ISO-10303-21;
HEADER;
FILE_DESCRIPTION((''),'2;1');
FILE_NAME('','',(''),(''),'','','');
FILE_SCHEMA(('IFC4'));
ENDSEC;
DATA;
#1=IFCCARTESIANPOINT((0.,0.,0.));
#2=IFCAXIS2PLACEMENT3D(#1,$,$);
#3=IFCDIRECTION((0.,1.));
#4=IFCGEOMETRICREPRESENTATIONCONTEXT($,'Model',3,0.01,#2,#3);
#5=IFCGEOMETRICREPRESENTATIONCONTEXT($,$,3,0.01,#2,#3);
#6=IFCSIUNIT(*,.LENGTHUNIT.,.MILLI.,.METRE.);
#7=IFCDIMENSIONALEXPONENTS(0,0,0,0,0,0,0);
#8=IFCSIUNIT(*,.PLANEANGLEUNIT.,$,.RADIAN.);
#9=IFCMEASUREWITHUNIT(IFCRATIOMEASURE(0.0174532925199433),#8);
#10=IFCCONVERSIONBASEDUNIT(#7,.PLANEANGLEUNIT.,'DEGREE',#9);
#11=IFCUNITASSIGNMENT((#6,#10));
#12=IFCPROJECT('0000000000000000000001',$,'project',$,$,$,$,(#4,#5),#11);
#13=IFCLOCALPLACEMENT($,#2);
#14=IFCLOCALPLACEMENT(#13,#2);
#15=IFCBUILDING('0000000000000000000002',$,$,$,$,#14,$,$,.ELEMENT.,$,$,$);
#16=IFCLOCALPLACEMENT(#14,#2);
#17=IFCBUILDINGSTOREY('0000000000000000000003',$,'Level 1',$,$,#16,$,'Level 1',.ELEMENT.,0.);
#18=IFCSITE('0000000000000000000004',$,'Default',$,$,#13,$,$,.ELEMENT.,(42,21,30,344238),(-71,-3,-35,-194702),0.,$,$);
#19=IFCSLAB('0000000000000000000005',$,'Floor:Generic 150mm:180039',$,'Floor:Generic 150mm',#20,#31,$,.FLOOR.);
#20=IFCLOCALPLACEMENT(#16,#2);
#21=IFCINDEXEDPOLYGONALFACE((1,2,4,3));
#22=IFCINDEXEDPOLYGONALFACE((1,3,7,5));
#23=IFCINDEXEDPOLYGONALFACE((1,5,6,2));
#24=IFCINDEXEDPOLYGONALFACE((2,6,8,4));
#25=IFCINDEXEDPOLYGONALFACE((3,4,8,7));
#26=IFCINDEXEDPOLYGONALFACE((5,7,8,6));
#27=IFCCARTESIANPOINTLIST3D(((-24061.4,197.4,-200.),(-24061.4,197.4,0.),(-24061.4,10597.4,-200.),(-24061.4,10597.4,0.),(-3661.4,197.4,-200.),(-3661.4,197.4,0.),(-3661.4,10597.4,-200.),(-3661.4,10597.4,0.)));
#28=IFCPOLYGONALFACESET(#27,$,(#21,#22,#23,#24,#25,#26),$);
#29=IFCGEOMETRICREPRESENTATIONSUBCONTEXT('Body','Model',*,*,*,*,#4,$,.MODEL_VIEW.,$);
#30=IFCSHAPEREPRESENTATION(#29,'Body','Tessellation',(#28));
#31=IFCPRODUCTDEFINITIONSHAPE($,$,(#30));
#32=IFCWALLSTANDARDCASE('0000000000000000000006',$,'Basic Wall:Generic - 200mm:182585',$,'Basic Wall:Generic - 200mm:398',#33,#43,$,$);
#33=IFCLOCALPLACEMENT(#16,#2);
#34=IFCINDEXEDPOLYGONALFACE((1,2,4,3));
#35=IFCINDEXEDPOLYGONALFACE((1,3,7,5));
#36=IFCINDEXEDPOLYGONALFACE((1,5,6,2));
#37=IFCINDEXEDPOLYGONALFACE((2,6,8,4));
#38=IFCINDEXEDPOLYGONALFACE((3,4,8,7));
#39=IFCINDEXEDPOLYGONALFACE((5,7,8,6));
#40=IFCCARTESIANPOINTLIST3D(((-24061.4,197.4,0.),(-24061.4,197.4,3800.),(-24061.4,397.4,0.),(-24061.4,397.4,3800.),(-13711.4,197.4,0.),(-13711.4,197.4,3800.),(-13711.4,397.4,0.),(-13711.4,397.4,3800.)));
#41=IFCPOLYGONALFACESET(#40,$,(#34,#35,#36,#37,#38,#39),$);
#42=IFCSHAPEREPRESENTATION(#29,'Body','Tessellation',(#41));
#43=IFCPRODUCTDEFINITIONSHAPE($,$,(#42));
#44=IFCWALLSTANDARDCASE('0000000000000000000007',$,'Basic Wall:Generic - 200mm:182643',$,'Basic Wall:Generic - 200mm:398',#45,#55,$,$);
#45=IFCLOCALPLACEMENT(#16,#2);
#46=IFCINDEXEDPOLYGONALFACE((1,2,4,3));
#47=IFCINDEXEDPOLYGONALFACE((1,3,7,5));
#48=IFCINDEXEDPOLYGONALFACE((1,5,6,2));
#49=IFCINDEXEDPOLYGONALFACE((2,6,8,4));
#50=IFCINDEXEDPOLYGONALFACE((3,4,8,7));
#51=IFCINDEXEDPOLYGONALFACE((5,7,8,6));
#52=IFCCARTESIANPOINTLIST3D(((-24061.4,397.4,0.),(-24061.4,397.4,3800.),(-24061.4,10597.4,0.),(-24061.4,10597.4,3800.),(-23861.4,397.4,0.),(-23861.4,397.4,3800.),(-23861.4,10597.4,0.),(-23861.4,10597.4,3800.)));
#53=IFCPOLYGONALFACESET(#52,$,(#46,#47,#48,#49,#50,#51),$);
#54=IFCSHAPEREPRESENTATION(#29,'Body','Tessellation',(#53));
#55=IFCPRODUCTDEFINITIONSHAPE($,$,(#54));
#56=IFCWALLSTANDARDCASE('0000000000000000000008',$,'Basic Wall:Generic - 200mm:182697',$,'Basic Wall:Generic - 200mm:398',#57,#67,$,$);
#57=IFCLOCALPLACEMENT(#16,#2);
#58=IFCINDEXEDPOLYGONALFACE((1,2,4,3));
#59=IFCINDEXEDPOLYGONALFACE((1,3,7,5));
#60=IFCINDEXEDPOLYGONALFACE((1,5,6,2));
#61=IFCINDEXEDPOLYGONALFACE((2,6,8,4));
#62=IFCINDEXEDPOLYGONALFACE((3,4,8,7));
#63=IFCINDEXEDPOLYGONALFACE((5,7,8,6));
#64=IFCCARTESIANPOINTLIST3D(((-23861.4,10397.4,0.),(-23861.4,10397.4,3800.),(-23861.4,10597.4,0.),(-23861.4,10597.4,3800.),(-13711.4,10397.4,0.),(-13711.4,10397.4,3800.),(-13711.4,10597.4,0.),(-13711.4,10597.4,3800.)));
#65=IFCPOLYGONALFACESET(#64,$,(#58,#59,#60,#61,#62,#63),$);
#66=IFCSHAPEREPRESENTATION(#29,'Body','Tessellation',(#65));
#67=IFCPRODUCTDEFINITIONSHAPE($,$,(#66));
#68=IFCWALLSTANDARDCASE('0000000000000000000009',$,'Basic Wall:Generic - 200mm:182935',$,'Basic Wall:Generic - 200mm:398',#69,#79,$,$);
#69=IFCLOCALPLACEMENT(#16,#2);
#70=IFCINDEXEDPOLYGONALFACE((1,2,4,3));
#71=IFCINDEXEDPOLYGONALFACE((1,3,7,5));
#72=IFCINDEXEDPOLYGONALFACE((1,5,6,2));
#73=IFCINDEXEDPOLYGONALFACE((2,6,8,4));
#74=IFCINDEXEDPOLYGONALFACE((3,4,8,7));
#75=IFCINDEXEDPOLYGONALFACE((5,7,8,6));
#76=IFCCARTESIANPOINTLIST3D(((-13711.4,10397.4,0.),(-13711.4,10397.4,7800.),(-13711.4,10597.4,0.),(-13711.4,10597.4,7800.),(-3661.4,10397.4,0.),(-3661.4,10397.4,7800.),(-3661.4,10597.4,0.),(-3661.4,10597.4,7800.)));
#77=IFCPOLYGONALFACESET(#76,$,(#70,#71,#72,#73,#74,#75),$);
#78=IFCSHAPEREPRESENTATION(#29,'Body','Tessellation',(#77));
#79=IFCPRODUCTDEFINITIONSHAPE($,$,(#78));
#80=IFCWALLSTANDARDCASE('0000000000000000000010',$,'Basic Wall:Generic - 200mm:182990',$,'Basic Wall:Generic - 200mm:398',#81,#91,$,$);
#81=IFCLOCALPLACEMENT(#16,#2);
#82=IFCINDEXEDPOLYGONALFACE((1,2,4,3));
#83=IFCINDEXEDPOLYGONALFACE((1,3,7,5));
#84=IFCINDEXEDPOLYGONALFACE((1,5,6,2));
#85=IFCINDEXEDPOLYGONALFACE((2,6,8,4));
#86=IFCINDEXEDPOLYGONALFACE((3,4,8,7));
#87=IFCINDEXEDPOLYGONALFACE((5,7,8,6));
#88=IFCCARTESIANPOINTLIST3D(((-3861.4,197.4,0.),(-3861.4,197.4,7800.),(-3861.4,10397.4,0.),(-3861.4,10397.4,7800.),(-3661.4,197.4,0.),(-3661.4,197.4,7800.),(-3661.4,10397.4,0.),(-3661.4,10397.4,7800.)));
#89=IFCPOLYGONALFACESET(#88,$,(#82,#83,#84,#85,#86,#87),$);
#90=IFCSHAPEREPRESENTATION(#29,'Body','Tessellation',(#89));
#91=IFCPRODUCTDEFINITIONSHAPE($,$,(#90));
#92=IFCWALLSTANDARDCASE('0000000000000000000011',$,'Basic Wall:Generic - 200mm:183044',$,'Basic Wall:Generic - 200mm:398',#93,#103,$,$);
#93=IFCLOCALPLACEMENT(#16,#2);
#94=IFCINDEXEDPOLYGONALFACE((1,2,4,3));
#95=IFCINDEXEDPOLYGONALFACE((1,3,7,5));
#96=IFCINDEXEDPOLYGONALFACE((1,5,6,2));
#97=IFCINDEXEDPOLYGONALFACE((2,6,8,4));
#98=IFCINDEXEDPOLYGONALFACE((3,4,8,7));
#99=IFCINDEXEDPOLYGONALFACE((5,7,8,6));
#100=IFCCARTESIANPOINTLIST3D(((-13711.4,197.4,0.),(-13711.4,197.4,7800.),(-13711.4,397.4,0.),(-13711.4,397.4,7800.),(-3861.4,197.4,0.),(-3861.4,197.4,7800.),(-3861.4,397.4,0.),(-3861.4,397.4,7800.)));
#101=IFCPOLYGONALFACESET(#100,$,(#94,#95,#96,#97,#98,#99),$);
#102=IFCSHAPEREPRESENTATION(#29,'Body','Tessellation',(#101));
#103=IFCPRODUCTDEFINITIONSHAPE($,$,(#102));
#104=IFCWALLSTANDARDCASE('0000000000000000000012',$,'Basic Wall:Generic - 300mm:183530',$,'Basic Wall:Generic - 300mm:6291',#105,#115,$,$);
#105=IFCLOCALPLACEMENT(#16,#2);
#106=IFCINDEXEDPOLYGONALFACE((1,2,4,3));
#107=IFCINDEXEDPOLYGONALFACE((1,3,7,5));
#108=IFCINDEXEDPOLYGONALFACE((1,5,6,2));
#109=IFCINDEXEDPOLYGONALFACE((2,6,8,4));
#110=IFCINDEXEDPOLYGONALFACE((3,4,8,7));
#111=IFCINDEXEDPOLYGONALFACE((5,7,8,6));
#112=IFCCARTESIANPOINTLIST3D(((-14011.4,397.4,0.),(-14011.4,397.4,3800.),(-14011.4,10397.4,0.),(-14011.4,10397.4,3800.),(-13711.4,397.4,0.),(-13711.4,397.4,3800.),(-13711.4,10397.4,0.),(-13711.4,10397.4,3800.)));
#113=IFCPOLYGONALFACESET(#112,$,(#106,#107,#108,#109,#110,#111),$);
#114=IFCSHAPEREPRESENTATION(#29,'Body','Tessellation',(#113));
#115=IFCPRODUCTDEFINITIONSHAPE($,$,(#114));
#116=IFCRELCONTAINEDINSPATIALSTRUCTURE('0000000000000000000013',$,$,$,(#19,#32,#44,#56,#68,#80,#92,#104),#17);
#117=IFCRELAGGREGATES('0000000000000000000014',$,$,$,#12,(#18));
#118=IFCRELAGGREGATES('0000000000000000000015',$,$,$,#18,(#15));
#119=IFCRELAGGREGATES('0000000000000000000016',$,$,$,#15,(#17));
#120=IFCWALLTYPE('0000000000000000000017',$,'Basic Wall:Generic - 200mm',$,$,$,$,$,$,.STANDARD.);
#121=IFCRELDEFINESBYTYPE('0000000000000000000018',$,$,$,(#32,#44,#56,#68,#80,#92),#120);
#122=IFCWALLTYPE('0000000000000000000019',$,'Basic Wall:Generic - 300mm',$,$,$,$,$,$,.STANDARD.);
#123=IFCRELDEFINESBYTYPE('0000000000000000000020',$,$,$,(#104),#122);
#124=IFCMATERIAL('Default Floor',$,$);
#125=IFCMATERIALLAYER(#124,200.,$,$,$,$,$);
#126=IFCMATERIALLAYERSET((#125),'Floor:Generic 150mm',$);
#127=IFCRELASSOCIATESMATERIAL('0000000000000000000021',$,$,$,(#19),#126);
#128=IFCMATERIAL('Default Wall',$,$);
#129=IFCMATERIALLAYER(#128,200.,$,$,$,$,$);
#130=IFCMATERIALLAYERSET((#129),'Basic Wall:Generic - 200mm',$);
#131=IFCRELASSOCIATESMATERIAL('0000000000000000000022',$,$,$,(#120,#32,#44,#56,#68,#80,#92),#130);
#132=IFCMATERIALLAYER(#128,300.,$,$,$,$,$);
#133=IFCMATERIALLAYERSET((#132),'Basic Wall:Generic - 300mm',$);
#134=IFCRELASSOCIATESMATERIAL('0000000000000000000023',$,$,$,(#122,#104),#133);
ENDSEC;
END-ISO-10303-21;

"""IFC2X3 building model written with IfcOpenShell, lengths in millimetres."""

from ifc_helpers import new_model, entity, si_unit, converted_unit, direction, frame, frame_2d, origin, origin_2d_with_axis, place, context, subcontext, project, spatial, rectangle, extrude, material, layer, layer_set, layer_usage, type_object, element, save


model = new_model("IFC2X3")

# Units and contexts
model_context = context("Model", 3, precision=0.01, world=origin(), true_north=direction((0.0, 1.0)))
context_of_model = context(None, 3, precision=0.01, world=origin(), true_north=direction((0.0, 1.0)))
body_context = subcontext(model_context, "Body", "Model", "MODEL_VIEW")
ifc_project = project(units=[si_unit("LENGTHUNIT", "METRE", prefix="MILLI"), converted_unit("PLANEANGLEUNIT", "DEGREE", entity("IfcRatioMeasure", 0.0174532925199433), si_unit("PLANEANGLEUNIT", "RADIAN"), dimensions=[0, 0, 0, 0, 0, 0, 0])], contexts=[model_context, context_of_model])

# Site, building, storey
site_placement = place(None, origin())
site = spatial("IfcSite", under=ifc_project, at=site_placement, Name="Default", CompositionType="ELEMENT", RefLatitude=(42, 21, 30, 344238), RefLongitude=(-71, -3, -35, -194702), RefElevation=0.0)
building_placement = place(site_placement, origin())
building = spatial("IfcBuilding", under=site, at=building_placement, CompositionType="ELEMENT")
storey_placement = place(building_placement, origin())
storey = spatial("IfcBuildingStorey", under=building, at=storey_placement, Name="Level 1", LongName="Level 1", CompositionType="ELEMENT", Elevation=0.0)

# Slab
ifc_material_1 = material(Name="Default Floor")
ifc_layer_1 = layer(ifc_material_1, 200.0)
ifc_layer_set_1 = layer_set([ifc_layer_1], Name="Floor:Generic 150mm")
ifc_layer_usage_1 = layer_usage(ifc_layer_set_1, "AXIS3", "POSITIVE", 0.0)
slab_placement = place(storey_placement, origin())
element("IfcSlab", 1, at=slab_placement, inside=storey, material=ifc_layer_usage_1, Name="Floor:Generic 150mm:180039", ObjectType="Floor:Generic 150mm", PredefinedType="FLOOR", context=body_context, shape_type="SweptSolid", body=[
    extrude(rectangle(XDim=10400.0, YDim=20400.0, at=origin_2d_with_axis()), frame((-13861.4, 5397.4, 0.0), z_axis=(0.0, 0.0, -1.0), x_axis=(0.0, 1.0, 0.0)), (0.0, 0.0, 1.0), 200.0),
])

# Walls
ifc_material_2 = material(Name="Default Wall")
ifc_layer_2 = layer(ifc_material_2, 200.0)
ifc_layer_set_2 = layer_set([ifc_layer_2], Name="Basic Wall:Generic - 200mm")
ifc_layer_usage_2 = layer_usage(ifc_layer_set_2, "AXIS2", "NEGATIVE", 100.0)
wall_type_1 = type_object("IfcWallType", Name="Basic Wall:Generic - 200mm", PredefinedType="STANDARD", material=ifc_layer_set_2)
wall_1_placement = place(storey_placement, frame((-13711.4, 297.4, 0.0), z_axis=(0.0, 0.0, 1.0), x_axis=(-1.0, 0.0, 0.0)))
element("IfcWallStandardCase", 2, at=wall_1_placement, inside=storey, type_object=wall_type_1, material=ifc_layer_usage_2, Name="Basic Wall:Generic - 200mm:182585", ObjectType="Basic Wall:Generic - 200mm:398", context=body_context, shape_type="SweptSolid", body=[
    extrude(rectangle(XDim=10350.0, YDim=200.0, at=frame_2d((5175.0, 0.0), x_axis=(-1.0, 0.0))), origin(), (0.0, 0.0, 1.0), 3800.0),
])
ifc_layer_usage_3 = layer_usage(ifc_layer_set_2, "AXIS2", "NEGATIVE", 100.0)
wall_2_placement = place(storey_placement, frame((-23961.4, 397.4, 0.0), z_axis=(0.0, 0.0, 1.0), x_axis=(0.0, 1.0, 0.0)))
element("IfcWallStandardCase", 3, at=wall_2_placement, inside=storey, type_object=wall_type_1, material=ifc_layer_usage_3, Name="Basic Wall:Generic - 200mm:182643", ObjectType="Basic Wall:Generic - 200mm:398", context=body_context, shape_type="SweptSolid", body=[
    extrude(rectangle(XDim=10200.0, YDim=200.0, at=frame_2d((5100.0, 0.0), x_axis=(-1.0, 0.0))), origin(), (0.0, 0.0, 1.0), 3800.0),
])
ifc_layer_usage_4 = layer_usage(ifc_layer_set_2, "AXIS2", "NEGATIVE", 100.0)
wall_3_placement = place(storey_placement, frame((-23861.4, 10497.4, 0.0)))
element("IfcWallStandardCase", 4, at=wall_3_placement, inside=storey, type_object=wall_type_1, material=ifc_layer_usage_4, Name="Basic Wall:Generic - 200mm:182697", ObjectType="Basic Wall:Generic - 200mm:398", context=body_context, shape_type="SweptSolid", body=[
    extrude(rectangle(XDim=10150.0, YDim=200.0, at=frame_2d((5075.0, 0.0), x_axis=(-1.0, 0.0))), origin(), (0.0, 0.0, 1.0), 3800.0),
])
ifc_layer_usage_5 = layer_usage(ifc_layer_set_2, "AXIS2", "NEGATIVE", 100.0)
wall_4_placement = place(storey_placement, frame((-13711.4, 10497.4, 0.0)))
element("IfcWallStandardCase", 5, at=wall_4_placement, inside=storey, type_object=wall_type_1, material=ifc_layer_usage_5, Name="Basic Wall:Generic - 200mm:182935", ObjectType="Basic Wall:Generic - 200mm:398", context=body_context, shape_type="SweptSolid", body=[
    extrude(rectangle(XDim=10050.0, YDim=200.0, at=frame_2d((5025.0, 0.0), x_axis=(-1.0, 0.0))), origin(), (0.0, 0.0, 1.0), 7800.0),
])
ifc_layer_usage_6 = layer_usage(ifc_layer_set_2, "AXIS2", "NEGATIVE", 100.0)
wall_5_placement = place(storey_placement, frame((-3761.4, 10397.4, 0.0), z_axis=(0.0, 0.0, 1.0), x_axis=(0.0, -1.0, 0.0)))
element("IfcWallStandardCase", 6, at=wall_5_placement, inside=storey, type_object=wall_type_1, material=ifc_layer_usage_6, Name="Basic Wall:Generic - 200mm:182990", ObjectType="Basic Wall:Generic - 200mm:398", context=body_context, shape_type="SweptSolid", body=[
    extrude(rectangle(XDim=10200.0, YDim=200.0, at=frame_2d((5100.0, 0.0), x_axis=(-1.0, 0.0))), origin(), (0.0, 0.0, 1.0), 7800.0),
])
ifc_layer_usage_7 = layer_usage(ifc_layer_set_2, "AXIS2", "NEGATIVE", 100.0)
wall_6_placement = place(storey_placement, frame((-3861.4, 297.4, 0.0), z_axis=(0.0, 0.0, 1.0), x_axis=(-1.0, 0.0, 0.0)))
element("IfcWallStandardCase", 7, at=wall_6_placement, inside=storey, type_object=wall_type_1, material=ifc_layer_usage_7, Name="Basic Wall:Generic - 200mm:183044", ObjectType="Basic Wall:Generic - 200mm:398", context=body_context, shape_type="SweptSolid", body=[
    extrude(rectangle(XDim=9850.0, YDim=200.0, at=frame_2d((4925.0, 0.0), x_axis=(-1.0, 0.0))), origin(), (0.0, 0.0, 1.0), 7800.0),
])
ifc_layer_3 = layer(ifc_material_2, 300.0)
ifc_layer_set_3 = layer_set([ifc_layer_3], Name="Basic Wall:Generic - 300mm")
ifc_layer_usage_8 = layer_usage(ifc_layer_set_3, "AXIS2", "NEGATIVE", 150.0)
wall_type_2 = type_object("IfcWallType", Name="Basic Wall:Generic - 300mm", PredefinedType="STANDARD", material=ifc_layer_set_3)
wall_7_placement = place(storey_placement, frame((-13861.4, 10397.4, 0.0), z_axis=(0.0, 0.0, 1.0), x_axis=(0.0, -1.0, 0.0)))
element("IfcWallStandardCase", 8, at=wall_7_placement, inside=storey, type_object=wall_type_2, material=ifc_layer_usage_8, Name="Basic Wall:Generic - 300mm:183530", ObjectType="Basic Wall:Generic - 300mm:6291", context=body_context, shape_type="SweptSolid", body=[
    extrude(rectangle(XDim=10000.0, YDim=300.0, at=frame_2d((5000.0, 0.0), x_axis=(-1.0, 0.0))), origin(), (0.0, 0.0, 1.0), 3800.0),
])

save(model, "model.ifc")
